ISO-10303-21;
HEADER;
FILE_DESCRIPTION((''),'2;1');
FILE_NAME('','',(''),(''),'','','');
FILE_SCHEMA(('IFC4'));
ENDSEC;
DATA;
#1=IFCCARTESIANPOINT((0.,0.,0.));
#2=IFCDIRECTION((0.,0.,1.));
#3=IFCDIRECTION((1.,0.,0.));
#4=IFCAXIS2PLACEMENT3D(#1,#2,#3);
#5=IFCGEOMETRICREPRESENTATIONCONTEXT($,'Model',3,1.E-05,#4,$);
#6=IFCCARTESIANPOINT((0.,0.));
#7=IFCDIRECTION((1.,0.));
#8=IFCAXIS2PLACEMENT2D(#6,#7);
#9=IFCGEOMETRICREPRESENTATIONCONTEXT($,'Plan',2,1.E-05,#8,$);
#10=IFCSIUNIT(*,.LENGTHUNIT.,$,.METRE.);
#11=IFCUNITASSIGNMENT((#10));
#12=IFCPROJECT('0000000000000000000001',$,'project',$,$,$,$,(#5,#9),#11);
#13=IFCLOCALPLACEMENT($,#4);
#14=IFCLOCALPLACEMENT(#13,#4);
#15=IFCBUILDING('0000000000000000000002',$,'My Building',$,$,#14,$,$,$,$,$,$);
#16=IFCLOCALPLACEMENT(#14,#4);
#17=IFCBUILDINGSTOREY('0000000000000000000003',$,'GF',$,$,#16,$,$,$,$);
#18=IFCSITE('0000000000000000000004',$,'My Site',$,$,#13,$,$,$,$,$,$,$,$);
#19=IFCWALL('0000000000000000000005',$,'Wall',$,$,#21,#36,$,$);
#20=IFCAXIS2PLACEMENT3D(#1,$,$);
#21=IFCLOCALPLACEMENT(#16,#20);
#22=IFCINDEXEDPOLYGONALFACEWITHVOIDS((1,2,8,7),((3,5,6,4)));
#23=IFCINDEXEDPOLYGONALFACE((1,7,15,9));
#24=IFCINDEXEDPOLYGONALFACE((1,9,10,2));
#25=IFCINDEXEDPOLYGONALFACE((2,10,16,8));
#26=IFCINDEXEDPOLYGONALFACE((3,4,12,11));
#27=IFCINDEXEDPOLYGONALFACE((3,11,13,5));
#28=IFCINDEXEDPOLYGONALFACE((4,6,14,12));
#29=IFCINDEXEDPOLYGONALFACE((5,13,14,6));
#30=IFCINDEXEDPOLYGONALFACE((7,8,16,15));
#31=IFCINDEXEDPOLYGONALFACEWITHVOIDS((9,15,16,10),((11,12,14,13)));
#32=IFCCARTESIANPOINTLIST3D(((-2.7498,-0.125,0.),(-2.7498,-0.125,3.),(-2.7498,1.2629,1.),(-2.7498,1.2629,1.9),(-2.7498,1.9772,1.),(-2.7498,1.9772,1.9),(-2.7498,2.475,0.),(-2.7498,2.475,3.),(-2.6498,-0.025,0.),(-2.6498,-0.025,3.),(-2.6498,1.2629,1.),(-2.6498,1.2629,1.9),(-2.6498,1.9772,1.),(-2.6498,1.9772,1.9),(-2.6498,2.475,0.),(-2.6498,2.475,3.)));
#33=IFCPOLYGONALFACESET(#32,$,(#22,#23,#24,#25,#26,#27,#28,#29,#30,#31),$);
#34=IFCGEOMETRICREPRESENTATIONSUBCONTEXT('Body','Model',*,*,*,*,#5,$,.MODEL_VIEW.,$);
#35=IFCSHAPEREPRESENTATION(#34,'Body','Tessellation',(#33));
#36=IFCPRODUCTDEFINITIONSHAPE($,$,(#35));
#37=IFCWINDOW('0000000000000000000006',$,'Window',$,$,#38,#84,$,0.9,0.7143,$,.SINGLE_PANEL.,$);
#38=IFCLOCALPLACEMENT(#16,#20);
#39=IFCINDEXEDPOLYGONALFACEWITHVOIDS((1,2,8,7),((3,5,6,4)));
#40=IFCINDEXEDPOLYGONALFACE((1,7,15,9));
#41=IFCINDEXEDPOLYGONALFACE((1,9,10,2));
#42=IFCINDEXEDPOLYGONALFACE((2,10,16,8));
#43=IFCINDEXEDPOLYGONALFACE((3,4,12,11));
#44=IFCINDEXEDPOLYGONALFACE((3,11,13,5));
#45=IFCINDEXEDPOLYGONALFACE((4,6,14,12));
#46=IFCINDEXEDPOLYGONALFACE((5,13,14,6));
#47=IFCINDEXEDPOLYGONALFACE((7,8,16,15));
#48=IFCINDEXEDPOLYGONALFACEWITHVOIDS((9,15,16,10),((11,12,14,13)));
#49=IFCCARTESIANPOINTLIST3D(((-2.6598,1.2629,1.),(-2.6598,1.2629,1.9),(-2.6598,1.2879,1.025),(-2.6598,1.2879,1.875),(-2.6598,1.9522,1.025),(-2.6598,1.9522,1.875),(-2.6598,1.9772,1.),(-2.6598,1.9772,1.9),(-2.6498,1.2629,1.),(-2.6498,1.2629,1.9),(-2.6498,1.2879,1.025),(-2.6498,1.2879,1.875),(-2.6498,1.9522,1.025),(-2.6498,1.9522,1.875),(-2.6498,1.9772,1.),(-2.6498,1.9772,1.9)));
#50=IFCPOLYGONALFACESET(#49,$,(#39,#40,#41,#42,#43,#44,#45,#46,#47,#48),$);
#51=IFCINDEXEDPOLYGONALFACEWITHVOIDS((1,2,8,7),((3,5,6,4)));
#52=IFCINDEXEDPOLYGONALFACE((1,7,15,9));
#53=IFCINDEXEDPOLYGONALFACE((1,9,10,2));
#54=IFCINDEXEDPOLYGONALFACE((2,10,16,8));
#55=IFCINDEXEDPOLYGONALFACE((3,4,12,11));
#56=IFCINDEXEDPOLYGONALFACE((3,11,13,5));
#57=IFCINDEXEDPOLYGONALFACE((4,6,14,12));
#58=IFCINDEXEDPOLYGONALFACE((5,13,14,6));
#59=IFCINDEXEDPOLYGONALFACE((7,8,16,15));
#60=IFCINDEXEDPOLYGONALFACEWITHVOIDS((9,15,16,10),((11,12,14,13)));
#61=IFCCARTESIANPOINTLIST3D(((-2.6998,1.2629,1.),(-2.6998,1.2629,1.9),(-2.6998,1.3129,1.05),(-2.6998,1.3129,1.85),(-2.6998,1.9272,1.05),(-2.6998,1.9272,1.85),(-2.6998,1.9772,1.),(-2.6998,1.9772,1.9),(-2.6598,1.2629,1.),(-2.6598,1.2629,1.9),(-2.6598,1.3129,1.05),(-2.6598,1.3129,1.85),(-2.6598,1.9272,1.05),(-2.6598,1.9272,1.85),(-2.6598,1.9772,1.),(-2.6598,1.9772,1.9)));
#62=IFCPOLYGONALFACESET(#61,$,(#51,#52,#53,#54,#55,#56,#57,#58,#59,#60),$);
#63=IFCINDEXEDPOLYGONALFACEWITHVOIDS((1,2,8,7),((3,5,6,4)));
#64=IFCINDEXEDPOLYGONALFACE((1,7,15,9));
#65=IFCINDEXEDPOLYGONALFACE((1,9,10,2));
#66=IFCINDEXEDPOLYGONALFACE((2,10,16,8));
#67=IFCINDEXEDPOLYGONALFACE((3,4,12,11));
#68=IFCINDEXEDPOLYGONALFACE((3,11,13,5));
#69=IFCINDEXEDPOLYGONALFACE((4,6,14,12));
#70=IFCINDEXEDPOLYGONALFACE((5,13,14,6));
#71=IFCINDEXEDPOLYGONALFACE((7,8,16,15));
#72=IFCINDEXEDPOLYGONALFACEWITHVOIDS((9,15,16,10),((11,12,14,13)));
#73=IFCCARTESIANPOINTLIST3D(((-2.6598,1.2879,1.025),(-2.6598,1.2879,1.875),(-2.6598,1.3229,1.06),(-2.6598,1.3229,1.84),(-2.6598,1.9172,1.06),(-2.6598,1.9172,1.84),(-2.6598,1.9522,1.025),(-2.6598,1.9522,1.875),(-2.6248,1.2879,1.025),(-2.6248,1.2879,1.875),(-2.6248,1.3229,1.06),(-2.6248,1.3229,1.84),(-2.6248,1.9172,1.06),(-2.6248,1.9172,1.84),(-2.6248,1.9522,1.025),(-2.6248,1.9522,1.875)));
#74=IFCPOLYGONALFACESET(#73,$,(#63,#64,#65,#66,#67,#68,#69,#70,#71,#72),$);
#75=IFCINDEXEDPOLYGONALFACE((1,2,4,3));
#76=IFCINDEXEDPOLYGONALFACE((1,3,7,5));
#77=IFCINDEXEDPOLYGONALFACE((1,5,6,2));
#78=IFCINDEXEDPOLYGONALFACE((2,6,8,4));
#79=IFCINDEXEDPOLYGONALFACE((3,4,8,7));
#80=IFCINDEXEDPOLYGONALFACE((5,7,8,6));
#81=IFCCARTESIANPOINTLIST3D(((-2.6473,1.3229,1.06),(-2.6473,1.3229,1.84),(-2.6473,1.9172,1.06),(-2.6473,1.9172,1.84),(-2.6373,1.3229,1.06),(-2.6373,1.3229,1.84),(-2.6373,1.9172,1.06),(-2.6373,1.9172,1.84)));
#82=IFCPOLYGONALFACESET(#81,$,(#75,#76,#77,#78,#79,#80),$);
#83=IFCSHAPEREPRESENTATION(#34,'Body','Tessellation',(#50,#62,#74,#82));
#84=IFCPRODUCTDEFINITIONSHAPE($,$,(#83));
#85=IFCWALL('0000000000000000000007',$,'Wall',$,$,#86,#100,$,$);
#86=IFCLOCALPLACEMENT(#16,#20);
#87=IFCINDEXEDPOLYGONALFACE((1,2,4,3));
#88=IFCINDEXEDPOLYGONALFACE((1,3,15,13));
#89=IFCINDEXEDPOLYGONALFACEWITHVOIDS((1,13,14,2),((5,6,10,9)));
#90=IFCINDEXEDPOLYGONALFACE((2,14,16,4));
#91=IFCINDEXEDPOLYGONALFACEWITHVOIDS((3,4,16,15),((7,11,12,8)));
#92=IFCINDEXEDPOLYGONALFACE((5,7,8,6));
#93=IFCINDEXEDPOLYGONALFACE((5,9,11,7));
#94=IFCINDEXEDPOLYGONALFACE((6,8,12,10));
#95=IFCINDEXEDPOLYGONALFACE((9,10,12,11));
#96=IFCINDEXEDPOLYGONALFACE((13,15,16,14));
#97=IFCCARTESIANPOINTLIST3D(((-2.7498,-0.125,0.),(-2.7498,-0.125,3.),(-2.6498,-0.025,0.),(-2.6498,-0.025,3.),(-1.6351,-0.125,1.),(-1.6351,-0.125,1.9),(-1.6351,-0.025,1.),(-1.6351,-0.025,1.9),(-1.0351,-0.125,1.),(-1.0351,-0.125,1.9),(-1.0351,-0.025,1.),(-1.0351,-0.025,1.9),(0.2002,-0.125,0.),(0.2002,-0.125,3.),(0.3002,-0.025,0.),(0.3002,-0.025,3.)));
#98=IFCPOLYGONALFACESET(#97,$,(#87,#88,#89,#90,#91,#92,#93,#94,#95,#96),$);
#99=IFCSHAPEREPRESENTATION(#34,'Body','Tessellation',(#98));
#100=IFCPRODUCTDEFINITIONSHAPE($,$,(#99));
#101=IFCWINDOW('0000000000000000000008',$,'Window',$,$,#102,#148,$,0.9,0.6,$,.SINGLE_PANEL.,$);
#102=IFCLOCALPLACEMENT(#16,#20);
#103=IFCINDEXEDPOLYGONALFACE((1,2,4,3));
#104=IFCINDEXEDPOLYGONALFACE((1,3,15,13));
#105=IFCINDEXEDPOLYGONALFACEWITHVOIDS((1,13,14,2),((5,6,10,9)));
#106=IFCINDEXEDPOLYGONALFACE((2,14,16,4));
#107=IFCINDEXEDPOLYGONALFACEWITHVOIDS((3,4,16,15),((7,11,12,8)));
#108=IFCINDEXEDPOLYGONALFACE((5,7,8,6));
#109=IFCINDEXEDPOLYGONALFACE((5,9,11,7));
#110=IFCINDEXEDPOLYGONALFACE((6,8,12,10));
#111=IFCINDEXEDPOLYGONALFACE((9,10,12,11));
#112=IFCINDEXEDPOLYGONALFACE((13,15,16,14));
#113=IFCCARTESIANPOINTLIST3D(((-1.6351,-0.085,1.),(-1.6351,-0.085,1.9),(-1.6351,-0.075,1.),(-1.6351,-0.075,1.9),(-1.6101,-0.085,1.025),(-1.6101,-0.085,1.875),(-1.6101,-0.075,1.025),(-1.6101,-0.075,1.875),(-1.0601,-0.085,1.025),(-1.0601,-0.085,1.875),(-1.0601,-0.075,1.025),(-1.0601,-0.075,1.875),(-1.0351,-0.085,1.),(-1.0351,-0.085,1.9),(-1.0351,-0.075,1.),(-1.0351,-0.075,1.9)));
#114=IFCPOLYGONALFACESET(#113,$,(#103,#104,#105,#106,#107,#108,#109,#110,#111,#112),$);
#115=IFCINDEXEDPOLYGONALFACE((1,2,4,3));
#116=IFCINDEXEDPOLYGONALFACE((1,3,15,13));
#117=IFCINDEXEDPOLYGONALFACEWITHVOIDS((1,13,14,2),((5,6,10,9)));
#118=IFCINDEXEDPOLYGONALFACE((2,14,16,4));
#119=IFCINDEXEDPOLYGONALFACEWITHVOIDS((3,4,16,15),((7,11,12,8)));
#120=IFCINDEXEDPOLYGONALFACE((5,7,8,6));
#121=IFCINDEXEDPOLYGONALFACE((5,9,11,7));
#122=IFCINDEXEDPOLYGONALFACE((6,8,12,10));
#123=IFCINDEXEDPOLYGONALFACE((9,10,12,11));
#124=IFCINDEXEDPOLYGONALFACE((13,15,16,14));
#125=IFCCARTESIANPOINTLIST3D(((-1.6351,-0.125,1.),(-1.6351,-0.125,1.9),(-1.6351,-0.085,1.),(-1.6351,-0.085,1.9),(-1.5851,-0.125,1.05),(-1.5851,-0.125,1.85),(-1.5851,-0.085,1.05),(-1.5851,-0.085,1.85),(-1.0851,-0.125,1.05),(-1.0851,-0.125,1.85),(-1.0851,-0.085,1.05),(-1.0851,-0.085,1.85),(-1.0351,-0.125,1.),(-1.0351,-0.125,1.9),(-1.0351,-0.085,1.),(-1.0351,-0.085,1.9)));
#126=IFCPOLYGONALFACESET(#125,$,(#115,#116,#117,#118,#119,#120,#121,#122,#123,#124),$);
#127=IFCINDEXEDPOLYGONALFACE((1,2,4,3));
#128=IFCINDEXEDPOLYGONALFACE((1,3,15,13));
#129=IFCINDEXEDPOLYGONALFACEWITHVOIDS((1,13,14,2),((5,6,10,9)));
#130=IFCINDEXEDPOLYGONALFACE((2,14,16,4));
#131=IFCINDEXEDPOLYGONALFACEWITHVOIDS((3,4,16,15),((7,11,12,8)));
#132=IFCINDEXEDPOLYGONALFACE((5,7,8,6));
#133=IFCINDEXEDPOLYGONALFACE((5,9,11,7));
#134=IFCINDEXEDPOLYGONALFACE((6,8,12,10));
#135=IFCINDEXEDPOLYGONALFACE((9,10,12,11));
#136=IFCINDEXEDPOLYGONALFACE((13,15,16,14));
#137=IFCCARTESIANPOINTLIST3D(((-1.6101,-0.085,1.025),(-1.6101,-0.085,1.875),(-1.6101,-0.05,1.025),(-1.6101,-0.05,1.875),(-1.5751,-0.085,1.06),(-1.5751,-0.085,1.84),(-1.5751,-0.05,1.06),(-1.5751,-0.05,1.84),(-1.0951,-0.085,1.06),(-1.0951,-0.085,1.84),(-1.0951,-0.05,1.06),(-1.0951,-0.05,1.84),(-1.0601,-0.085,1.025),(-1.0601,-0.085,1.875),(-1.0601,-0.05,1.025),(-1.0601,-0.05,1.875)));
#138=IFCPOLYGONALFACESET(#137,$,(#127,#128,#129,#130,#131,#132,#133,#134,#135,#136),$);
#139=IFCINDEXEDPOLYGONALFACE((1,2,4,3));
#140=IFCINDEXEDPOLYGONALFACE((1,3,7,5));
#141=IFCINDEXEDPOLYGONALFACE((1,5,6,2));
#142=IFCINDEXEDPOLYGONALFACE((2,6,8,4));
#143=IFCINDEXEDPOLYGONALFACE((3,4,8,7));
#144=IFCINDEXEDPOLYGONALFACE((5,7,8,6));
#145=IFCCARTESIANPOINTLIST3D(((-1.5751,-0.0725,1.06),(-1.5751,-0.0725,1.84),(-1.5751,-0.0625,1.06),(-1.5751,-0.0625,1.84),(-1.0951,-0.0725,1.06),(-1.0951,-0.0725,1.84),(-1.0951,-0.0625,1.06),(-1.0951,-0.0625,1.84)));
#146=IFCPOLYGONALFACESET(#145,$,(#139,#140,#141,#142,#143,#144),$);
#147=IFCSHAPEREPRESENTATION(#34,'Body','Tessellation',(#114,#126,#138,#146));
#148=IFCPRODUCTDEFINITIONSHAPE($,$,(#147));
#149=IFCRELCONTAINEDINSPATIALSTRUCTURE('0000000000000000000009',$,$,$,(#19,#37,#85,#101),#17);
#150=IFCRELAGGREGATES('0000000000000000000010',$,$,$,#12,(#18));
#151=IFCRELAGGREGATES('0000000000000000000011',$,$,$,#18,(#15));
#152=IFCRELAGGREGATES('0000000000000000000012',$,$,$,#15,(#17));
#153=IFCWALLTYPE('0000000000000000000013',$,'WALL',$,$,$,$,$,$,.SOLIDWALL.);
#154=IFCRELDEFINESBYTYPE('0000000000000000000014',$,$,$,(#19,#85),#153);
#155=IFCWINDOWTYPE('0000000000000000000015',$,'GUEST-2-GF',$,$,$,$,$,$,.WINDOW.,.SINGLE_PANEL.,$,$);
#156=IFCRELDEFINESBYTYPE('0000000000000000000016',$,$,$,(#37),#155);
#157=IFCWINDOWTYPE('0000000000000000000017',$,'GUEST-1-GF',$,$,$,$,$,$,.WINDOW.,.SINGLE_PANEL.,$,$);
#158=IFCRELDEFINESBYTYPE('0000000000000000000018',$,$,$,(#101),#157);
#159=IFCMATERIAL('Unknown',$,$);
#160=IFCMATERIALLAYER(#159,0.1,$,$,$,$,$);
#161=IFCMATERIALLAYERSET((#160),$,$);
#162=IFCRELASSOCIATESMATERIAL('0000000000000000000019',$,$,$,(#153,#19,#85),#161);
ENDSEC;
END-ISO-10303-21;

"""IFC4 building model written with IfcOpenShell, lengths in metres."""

from ifc_helpers import new_model, entity, si_unit, frame, origin_with_axes, origin_2d_with_axis, place, context, subcontext, project, spatial, line, indexed_curve, outline, extrude, shape, source, transform, mapped, material, layer, layer_set, layer_usage, type_object, type_shapes, element, fill, save


model = new_model("IFC4")

# Units and contexts
model_context = context("Model", 3, precision=1e-05, world=origin_with_axes())
plan_context = context("Plan", 2, precision=1e-05, world=origin_2d_with_axis())
body_context_1 = subcontext(model_context, "Body", "Model", "MODEL_VIEW")
body_context_2 = subcontext(plan_context, "Body", "Plan", "PLAN_VIEW")
ifc_project = project(units=[si_unit("LENGTHUNIT", "METRE")], contexts=[model_context, plan_context])

# Site, building, storey
site_placement = place(None, origin_with_axes())
site = spatial("IfcSite", under=ifc_project, at=site_placement, Name="My Site")
building_placement = place(site_placement, origin_with_axes())
building = spatial("IfcBuilding", under=site, at=building_placement, Name="My Building")
storey_placement = place(building_placement, origin_with_axes())
storey = spatial("IfcBuildingStorey", under=building, at=storey_placement, Name="GF")

# Shared definitions
ifc_material_1 = material(Name="Unknown")

# Shared definitions
ifc_layer_1 = layer(ifc_material_1, 0.1)
ifc_layer_set_1 = layer_set([ifc_layer_1])
wall_type = type_object("IfcWallType", Name="WALL", PredefinedType="SOLIDWALL", material=ifc_layer_set_1)

# Walls, openings, windows
ifc_layer_usage_1 = layer_usage(ifc_layer_set_1, "AXIS2", "POSITIVE", 0.0)
wall_1_placement = place(storey_placement, frame((-2.7498, 2.475, 0.0), z_axis=(0.0, 0.0, 1.0), x_axis=(0.0, -1.0, 0.0)))
wall_1 = element("IfcWall", 1, at=wall_1_placement, inside=storey, type_object=wall_type, material=ifc_layer_usage_1, Name="Wall", context=body_context_1, shape_type="SweptSolid", body=[
    extrude(outline(indexed_curve([(0.0, 0.0), (0.0, 0.1), (2.5, 0.1), (2.6, 0.0)], segments=[line(1, 2, 3, 4, 1)])), origin_with_axes(), (0.0, 0.0, 1.0), 3.0),
])
shared_shape_1 = source(origin_with_axes(), body_context_1, "Body", "SweptSolid", [
    extrude(outline(indexed_curve([(0.0, 0.0), (0.7143, 0.0), (0.7143, 0.9), (0.0, 0.9)], segments=[line(1, 2, 3, 4, 1)])), frame((0.0, -0.6, 0.0), z_axis=(0.0, -1.0, 0.0), x_axis=(1.0, 0.0, 0.0)), (0.0, 0.0, -1.0), 1.2),
])
opening_1_placement = place(wall_1_placement, frame((0.4978, 0.0, 1.0), z_axis=(0.0, 0.0, 1.0), x_axis=(1.0, 0.0, 0.0)))
opening_1 = element("IfcOpeningElement", 2, at=opening_1_placement, cuts=wall_1, PredefinedType="OPENING", context=body_context_1, shape_type="MappedRepresentation", body=[
    mapped(shared_shape_1, transform((0.0, 0.0, 0.0), x_axis=(1.0, 0.0, 0.0), y_axis=(0.0, 1.0, 0.0), z_axis=(0.0, 0.0, 1.0), scale=1.0)),
])
window_type_1 = type_object("IfcWindowType", Name="GUEST-2-GF", PartitioningType="SINGLE_PANEL", PredefinedType="WINDOW")
shared_shape_2 = source(origin_with_axes(), body_context_1, "Body", "SweptSolid", [
    extrude(outline(indexed_curve([(0.0, 0.0), (0.7143, 0.0), (0.7143, 0.9), (0.0, 0.9)], segments=[line(1, 2, 3, 4, 1)]), holes=[indexed_curve([(0.025, 0.025), (0.6893, 0.025), (0.6893, 0.875), (0.025, 0.875)], segments=[line(1, 2, 3, 4, 1)])]), frame((0.0, 0.09, 0.0), z_axis=(0.0, -1.0, 0.0), x_axis=(1.0, 0.0, 0.0)), (0.0, 0.0, -1.0), 0.01),
    extrude(outline(indexed_curve([(0.0, 0.0), (0.7143, 0.0), (0.7143, 0.9), (0.0, 0.9)], segments=[line(1, 2, 3, 4, 1)]), holes=[indexed_curve([(0.05, 0.05), (0.6643, 0.05), (0.6643, 0.85), (0.05, 0.85)], segments=[line(1, 2, 3, 4, 1)])]), frame((0.0, 0.05, 0.0), z_axis=(0.0, -1.0, 0.0), x_axis=(1.0, 0.0, 0.0)), (0.0, 0.0, -1.0), 0.04),
    extrude(outline(indexed_curve([(0.0, 0.0), (0.6643, 0.0), (0.6643, 0.85), (0.0, 0.85)], segments=[line(1, 2, 3, 4, 1)]), holes=[indexed_curve([(0.035, 0.035), (0.6293, 0.035), (0.6293, 0.815), (0.035, 0.815)], segments=[line(1, 2, 3, 4, 1)])]), frame((0.025, 0.09, 0.025), z_axis=(0.0, -1.0, 0.0), x_axis=(1.0, 0.0, 0.0)), (0.0, 0.0, -1.0), 0.035),
    extrude(outline(indexed_curve([(0.035, 0.035), (0.6293, 0.035), (0.6293, 0.815), (0.035, 0.815)], segments=[line(1, 2, 3, 4, 1)])), frame((0.025, 0.1025, 0.025), z_axis=(0.0, -1.0, 0.0), x_axis=(1.0, 0.0, 0.0)), (0.0, 0.0, -1.0), 0.01),
])
shared_shape_3 = source(origin_with_axes(), body_context_2, "Body", "Curve2D", [
    entity("IfcIndexedPolyCurve", entity("IfcCartesianPointList2D", [[0.05, 0.05], [0.6643, 0.05]])),
    entity("IfcIndexedPolyCurve", entity("IfcCartesianPointList2D", [[0.0, 0.1], [0.025, 0.1], [0.025, 0.09], [0.05, 0.09], [0.05, 0.05], [0.0, 0.05]]), [entity("IfcLineIndex", [1, 2, 3, 4, 5, 6, 1])]),
    entity("IfcIndexedPolyCurve", entity("IfcCartesianPointList2D", [[0.7143, 0.1], [0.6893, 0.1], [0.6893, 0.09], [0.6643, 0.09], [0.6643, 0.05], [0.7143, 0.05]]), [entity("IfcLineIndex", [1, 2, 3, 4, 5, 6, 1])]),
    entity("IfcIndexedPolyCurve", entity("IfcCartesianPointList2D", [[0.025, 0.09], [0.06, 0.09], [0.06, 0.125], [0.025, 0.125]]), [entity("IfcLineIndex", [1, 2, 3, 4, 1])]),
    entity("IfcIndexedPolyCurve", entity("IfcCartesianPointList2D", [[0.6893, 0.09], [0.6543, 0.09], [0.6543, 0.125], [0.6893, 0.125]]), [entity("IfcLineIndex", [1, 2, 3, 4, 1])]),
    entity("IfcIndexedPolyCurve", entity("IfcCartesianPointList2D", [[0.06, 0.09], [0.6543, 0.09]])),
    entity("IfcIndexedPolyCurve", entity("IfcCartesianPointList2D", [[0.06, 0.125], [0.6543, 0.125]])),
    entity("IfcIndexedPolyCurve", entity("IfcCartesianPointList2D", [[0.06, 0.1075], [0.6543, 0.1075]])),
])
type_shapes(window_type_1, [shared_shape_2, shared_shape_3])
window_1_placement = place(opening_1_placement, frame((0.0, 0.0, 0.0), z_axis=(0.0, 0.0, 1.0), x_axis=(1.0, 0.0, 0.0)))
window_1 = element("IfcWindow", 3, at=window_1_placement, inside=storey, type_object=window_type_1, Name="Window", OverallHeight=0.9, OverallWidth=0.7143, PartitioningType="SINGLE_PANEL", shapes=[
    shape(body_context_1, "Body", "MappedRepresentation", [mapped(shared_shape_2, transform((0.0, 0.0, 0.0), x_axis=(1.0, 0.0, 0.0), y_axis=(0.0, 1.0, 0.0), z_axis=(0.0, 0.0, 1.0), scale=1.0))]),
    shape(body_context_2, "Body", "MappedRepresentation", [mapped(shared_shape_3, transform((0.0, 0.0, 0.0), x_axis=(1.0, 0.0, 0.0), y_axis=(0.0, 1.0, 0.0), z_axis=(0.0, 0.0, 1.0), scale=1.0))]),
])
fill(opening_1, window_1)
ifc_layer_usage_2 = layer_usage(ifc_layer_set_1, "AXIS2", "POSITIVE", 0.0)
wall_2_placement = place(storey_placement, frame((-2.7498, -0.125, 0.0), z_axis=(0.0, 0.0, 1.0), x_axis=(1.0, 0.0, 0.0)))
wall_2 = element("IfcWall", 4, at=wall_2_placement, inside=storey, type_object=wall_type, material=ifc_layer_usage_2, Name="Wall", context=body_context_1, shape_type="SweptSolid", body=[
    extrude(outline(indexed_curve([(0.0, 0.0), (0.1, 0.1), (3.05, 0.1), (2.95, 0.0)], segments=[line(1, 2, 3, 4, 1)])), origin_with_axes(), (0.0, 0.0, 1.0), 3.0),
])
shared_shape_4 = source(origin_with_axes(), body_context_1, "Body", "SweptSolid", [
    extrude(outline(indexed_curve([(0.0, 0.0), (0.6, 0.0), (0.6, 0.9), (0.0, 0.9)], segments=[line(1, 2, 3, 4, 1)])), frame((0.0, -0.6, 0.0), z_axis=(0.0, -1.0, 0.0), x_axis=(1.0, 0.0, 0.0)), (0.0, 0.0, -1.0), 1.2),
])
opening_2_placement = place(wall_2_placement, frame((1.1146, -0.05, 1.0), z_axis=(0.0, 0.0, 1.0), x_axis=(1.0, 0.0, 0.0)))
opening_2 = element("IfcOpeningElement", 5, at=opening_2_placement, cuts=wall_2, PredefinedType="OPENING", context=body_context_1, shape_type="MappedRepresentation", body=[
    mapped(shared_shape_4, transform((0.0, 0.0, 0.0), x_axis=(1.0, 0.0, 0.0), y_axis=(0.0, 1.0, 0.0), z_axis=(0.0, 0.0, 1.0), scale=1.0)),
])
window_type_2 = type_object("IfcWindowType", Name="GUEST-1-GF", PartitioningType="SINGLE_PANEL", PredefinedType="WINDOW")
shared_shape_5 = source(origin_with_axes(), body_context_1, "Body", "SweptSolid", [
    extrude(outline(indexed_curve([(0.0, 0.0), (0.6, 0.0), (0.6, 0.9), (0.0, 0.9)], segments=[line(1, 2, 3, 4, 1)]), holes=[indexed_curve([(0.025, 0.025), (0.575, 0.025), (0.575, 0.875), (0.025, 0.875)], segments=[line(1, 2, 3, 4, 1)])]), frame((0.0, 0.09, 0.0), z_axis=(0.0, -1.0, 0.0), x_axis=(1.0, 0.0, 0.0)), (0.0, 0.0, -1.0), 0.01),
    extrude(outline(indexed_curve([(0.0, 0.0), (0.6, 0.0), (0.6, 0.9), (0.0, 0.9)], segments=[line(1, 2, 3, 4, 1)]), holes=[indexed_curve([(0.05, 0.05), (0.55, 0.05), (0.55, 0.85), (0.05, 0.85)], segments=[line(1, 2, 3, 4, 1)])]), frame((0.0, 0.05, 0.0), z_axis=(0.0, -1.0, 0.0), x_axis=(1.0, 0.0, 0.0)), (0.0, 0.0, -1.0), 0.04),
    extrude(outline(indexed_curve([(0.0, 0.0), (0.55, 0.0), (0.55, 0.85), (0.0, 0.85)], segments=[line(1, 2, 3, 4, 1)]), holes=[indexed_curve([(0.035, 0.035), (0.515, 0.035), (0.515, 0.815), (0.035, 0.815)], segments=[line(1, 2, 3, 4, 1)])]), frame((0.025, 0.09, 0.025), z_axis=(0.0, -1.0, 0.0), x_axis=(1.0, 0.0, 0.0)), (0.0, 0.0, -1.0), 0.035),
    extrude(outline(indexed_curve([(0.035, 0.035), (0.515, 0.035), (0.515, 0.815), (0.035, 0.815)], segments=[line(1, 2, 3, 4, 1)])), frame((0.025, 0.1025, 0.025), z_axis=(0.0, -1.0, 0.0), x_axis=(1.0, 0.0, 0.0)), (0.0, 0.0, -1.0), 0.01),
])
shared_shape_6 = source(origin_with_axes(), body_context_2, "Body", "Curve2D", [
    entity("IfcIndexedPolyCurve", entity("IfcCartesianPointList2D", [[0.05, 0.05], [0.55, 0.05]])),
    entity("IfcIndexedPolyCurve", entity("IfcCartesianPointList2D", [[0.0, 0.1], [0.025, 0.1], [0.025, 0.09], [0.05, 0.09], [0.05, 0.05], [0.0, 0.05]]), [entity("IfcLineIndex", [1, 2, 3, 4, 5, 6, 1])]),
    entity("IfcIndexedPolyCurve", entity("IfcCartesianPointList2D", [[0.6, 0.1], [0.575, 0.1], [0.575, 0.09], [0.55, 0.09], [0.55, 0.05], [0.6, 0.05]]), [entity("IfcLineIndex", [1, 2, 3, 4, 5, 6, 1])]),
    entity("IfcIndexedPolyCurve", entity("IfcCartesianPointList2D", [[0.025, 0.09], [0.06, 0.09], [0.06, 0.125], [0.025, 0.125]]), [entity("IfcLineIndex", [1, 2, 3, 4, 1])]),
    entity("IfcIndexedPolyCurve", entity("IfcCartesianPointList2D", [[0.575, 0.09], [0.54, 0.09], [0.54, 0.125], [0.575, 0.125]]), [entity("IfcLineIndex", [1, 2, 3, 4, 1])]),
    entity("IfcIndexedPolyCurve", entity("IfcCartesianPointList2D", [[0.06, 0.09], [0.54, 0.09]])),
    entity("IfcIndexedPolyCurve", entity("IfcCartesianPointList2D", [[0.06, 0.125], [0.54, 0.125]])),
    entity("IfcIndexedPolyCurve", entity("IfcCartesianPointList2D", [[0.06, 0.1075], [0.54, 0.1075]])),
])
type_shapes(window_type_2, [shared_shape_5, shared_shape_6])
window_2_placement = place(opening_2_placement, frame((0.0, 0.0, 0.0), z_axis=(0.0, 0.0, 1.0), x_axis=(1.0, 0.0, 0.0)))
window_2 = element("IfcWindow", 6, at=window_2_placement, inside=storey, type_object=window_type_2, Name="Window", OverallHeight=0.9, OverallWidth=0.6, PartitioningType="SINGLE_PANEL", shapes=[
    shape(body_context_1, "Body", "MappedRepresentation", [mapped(shared_shape_5, transform((0.0, 0.0, 0.0), x_axis=(1.0, 0.0, 0.0), y_axis=(0.0, 1.0, 0.0), z_axis=(0.0, 0.0, 1.0), scale=1.0))]),
    shape(body_context_2, "Body", "MappedRepresentation", [mapped(shared_shape_6, transform((0.0, 0.0, 0.0), x_axis=(1.0, 0.0, 0.0), y_axis=(0.0, 1.0, 0.0), z_axis=(0.0, 0.0, 1.0), scale=1.0))]),
])
fill(opening_2, window_2)

save(model, "model.ifc")
